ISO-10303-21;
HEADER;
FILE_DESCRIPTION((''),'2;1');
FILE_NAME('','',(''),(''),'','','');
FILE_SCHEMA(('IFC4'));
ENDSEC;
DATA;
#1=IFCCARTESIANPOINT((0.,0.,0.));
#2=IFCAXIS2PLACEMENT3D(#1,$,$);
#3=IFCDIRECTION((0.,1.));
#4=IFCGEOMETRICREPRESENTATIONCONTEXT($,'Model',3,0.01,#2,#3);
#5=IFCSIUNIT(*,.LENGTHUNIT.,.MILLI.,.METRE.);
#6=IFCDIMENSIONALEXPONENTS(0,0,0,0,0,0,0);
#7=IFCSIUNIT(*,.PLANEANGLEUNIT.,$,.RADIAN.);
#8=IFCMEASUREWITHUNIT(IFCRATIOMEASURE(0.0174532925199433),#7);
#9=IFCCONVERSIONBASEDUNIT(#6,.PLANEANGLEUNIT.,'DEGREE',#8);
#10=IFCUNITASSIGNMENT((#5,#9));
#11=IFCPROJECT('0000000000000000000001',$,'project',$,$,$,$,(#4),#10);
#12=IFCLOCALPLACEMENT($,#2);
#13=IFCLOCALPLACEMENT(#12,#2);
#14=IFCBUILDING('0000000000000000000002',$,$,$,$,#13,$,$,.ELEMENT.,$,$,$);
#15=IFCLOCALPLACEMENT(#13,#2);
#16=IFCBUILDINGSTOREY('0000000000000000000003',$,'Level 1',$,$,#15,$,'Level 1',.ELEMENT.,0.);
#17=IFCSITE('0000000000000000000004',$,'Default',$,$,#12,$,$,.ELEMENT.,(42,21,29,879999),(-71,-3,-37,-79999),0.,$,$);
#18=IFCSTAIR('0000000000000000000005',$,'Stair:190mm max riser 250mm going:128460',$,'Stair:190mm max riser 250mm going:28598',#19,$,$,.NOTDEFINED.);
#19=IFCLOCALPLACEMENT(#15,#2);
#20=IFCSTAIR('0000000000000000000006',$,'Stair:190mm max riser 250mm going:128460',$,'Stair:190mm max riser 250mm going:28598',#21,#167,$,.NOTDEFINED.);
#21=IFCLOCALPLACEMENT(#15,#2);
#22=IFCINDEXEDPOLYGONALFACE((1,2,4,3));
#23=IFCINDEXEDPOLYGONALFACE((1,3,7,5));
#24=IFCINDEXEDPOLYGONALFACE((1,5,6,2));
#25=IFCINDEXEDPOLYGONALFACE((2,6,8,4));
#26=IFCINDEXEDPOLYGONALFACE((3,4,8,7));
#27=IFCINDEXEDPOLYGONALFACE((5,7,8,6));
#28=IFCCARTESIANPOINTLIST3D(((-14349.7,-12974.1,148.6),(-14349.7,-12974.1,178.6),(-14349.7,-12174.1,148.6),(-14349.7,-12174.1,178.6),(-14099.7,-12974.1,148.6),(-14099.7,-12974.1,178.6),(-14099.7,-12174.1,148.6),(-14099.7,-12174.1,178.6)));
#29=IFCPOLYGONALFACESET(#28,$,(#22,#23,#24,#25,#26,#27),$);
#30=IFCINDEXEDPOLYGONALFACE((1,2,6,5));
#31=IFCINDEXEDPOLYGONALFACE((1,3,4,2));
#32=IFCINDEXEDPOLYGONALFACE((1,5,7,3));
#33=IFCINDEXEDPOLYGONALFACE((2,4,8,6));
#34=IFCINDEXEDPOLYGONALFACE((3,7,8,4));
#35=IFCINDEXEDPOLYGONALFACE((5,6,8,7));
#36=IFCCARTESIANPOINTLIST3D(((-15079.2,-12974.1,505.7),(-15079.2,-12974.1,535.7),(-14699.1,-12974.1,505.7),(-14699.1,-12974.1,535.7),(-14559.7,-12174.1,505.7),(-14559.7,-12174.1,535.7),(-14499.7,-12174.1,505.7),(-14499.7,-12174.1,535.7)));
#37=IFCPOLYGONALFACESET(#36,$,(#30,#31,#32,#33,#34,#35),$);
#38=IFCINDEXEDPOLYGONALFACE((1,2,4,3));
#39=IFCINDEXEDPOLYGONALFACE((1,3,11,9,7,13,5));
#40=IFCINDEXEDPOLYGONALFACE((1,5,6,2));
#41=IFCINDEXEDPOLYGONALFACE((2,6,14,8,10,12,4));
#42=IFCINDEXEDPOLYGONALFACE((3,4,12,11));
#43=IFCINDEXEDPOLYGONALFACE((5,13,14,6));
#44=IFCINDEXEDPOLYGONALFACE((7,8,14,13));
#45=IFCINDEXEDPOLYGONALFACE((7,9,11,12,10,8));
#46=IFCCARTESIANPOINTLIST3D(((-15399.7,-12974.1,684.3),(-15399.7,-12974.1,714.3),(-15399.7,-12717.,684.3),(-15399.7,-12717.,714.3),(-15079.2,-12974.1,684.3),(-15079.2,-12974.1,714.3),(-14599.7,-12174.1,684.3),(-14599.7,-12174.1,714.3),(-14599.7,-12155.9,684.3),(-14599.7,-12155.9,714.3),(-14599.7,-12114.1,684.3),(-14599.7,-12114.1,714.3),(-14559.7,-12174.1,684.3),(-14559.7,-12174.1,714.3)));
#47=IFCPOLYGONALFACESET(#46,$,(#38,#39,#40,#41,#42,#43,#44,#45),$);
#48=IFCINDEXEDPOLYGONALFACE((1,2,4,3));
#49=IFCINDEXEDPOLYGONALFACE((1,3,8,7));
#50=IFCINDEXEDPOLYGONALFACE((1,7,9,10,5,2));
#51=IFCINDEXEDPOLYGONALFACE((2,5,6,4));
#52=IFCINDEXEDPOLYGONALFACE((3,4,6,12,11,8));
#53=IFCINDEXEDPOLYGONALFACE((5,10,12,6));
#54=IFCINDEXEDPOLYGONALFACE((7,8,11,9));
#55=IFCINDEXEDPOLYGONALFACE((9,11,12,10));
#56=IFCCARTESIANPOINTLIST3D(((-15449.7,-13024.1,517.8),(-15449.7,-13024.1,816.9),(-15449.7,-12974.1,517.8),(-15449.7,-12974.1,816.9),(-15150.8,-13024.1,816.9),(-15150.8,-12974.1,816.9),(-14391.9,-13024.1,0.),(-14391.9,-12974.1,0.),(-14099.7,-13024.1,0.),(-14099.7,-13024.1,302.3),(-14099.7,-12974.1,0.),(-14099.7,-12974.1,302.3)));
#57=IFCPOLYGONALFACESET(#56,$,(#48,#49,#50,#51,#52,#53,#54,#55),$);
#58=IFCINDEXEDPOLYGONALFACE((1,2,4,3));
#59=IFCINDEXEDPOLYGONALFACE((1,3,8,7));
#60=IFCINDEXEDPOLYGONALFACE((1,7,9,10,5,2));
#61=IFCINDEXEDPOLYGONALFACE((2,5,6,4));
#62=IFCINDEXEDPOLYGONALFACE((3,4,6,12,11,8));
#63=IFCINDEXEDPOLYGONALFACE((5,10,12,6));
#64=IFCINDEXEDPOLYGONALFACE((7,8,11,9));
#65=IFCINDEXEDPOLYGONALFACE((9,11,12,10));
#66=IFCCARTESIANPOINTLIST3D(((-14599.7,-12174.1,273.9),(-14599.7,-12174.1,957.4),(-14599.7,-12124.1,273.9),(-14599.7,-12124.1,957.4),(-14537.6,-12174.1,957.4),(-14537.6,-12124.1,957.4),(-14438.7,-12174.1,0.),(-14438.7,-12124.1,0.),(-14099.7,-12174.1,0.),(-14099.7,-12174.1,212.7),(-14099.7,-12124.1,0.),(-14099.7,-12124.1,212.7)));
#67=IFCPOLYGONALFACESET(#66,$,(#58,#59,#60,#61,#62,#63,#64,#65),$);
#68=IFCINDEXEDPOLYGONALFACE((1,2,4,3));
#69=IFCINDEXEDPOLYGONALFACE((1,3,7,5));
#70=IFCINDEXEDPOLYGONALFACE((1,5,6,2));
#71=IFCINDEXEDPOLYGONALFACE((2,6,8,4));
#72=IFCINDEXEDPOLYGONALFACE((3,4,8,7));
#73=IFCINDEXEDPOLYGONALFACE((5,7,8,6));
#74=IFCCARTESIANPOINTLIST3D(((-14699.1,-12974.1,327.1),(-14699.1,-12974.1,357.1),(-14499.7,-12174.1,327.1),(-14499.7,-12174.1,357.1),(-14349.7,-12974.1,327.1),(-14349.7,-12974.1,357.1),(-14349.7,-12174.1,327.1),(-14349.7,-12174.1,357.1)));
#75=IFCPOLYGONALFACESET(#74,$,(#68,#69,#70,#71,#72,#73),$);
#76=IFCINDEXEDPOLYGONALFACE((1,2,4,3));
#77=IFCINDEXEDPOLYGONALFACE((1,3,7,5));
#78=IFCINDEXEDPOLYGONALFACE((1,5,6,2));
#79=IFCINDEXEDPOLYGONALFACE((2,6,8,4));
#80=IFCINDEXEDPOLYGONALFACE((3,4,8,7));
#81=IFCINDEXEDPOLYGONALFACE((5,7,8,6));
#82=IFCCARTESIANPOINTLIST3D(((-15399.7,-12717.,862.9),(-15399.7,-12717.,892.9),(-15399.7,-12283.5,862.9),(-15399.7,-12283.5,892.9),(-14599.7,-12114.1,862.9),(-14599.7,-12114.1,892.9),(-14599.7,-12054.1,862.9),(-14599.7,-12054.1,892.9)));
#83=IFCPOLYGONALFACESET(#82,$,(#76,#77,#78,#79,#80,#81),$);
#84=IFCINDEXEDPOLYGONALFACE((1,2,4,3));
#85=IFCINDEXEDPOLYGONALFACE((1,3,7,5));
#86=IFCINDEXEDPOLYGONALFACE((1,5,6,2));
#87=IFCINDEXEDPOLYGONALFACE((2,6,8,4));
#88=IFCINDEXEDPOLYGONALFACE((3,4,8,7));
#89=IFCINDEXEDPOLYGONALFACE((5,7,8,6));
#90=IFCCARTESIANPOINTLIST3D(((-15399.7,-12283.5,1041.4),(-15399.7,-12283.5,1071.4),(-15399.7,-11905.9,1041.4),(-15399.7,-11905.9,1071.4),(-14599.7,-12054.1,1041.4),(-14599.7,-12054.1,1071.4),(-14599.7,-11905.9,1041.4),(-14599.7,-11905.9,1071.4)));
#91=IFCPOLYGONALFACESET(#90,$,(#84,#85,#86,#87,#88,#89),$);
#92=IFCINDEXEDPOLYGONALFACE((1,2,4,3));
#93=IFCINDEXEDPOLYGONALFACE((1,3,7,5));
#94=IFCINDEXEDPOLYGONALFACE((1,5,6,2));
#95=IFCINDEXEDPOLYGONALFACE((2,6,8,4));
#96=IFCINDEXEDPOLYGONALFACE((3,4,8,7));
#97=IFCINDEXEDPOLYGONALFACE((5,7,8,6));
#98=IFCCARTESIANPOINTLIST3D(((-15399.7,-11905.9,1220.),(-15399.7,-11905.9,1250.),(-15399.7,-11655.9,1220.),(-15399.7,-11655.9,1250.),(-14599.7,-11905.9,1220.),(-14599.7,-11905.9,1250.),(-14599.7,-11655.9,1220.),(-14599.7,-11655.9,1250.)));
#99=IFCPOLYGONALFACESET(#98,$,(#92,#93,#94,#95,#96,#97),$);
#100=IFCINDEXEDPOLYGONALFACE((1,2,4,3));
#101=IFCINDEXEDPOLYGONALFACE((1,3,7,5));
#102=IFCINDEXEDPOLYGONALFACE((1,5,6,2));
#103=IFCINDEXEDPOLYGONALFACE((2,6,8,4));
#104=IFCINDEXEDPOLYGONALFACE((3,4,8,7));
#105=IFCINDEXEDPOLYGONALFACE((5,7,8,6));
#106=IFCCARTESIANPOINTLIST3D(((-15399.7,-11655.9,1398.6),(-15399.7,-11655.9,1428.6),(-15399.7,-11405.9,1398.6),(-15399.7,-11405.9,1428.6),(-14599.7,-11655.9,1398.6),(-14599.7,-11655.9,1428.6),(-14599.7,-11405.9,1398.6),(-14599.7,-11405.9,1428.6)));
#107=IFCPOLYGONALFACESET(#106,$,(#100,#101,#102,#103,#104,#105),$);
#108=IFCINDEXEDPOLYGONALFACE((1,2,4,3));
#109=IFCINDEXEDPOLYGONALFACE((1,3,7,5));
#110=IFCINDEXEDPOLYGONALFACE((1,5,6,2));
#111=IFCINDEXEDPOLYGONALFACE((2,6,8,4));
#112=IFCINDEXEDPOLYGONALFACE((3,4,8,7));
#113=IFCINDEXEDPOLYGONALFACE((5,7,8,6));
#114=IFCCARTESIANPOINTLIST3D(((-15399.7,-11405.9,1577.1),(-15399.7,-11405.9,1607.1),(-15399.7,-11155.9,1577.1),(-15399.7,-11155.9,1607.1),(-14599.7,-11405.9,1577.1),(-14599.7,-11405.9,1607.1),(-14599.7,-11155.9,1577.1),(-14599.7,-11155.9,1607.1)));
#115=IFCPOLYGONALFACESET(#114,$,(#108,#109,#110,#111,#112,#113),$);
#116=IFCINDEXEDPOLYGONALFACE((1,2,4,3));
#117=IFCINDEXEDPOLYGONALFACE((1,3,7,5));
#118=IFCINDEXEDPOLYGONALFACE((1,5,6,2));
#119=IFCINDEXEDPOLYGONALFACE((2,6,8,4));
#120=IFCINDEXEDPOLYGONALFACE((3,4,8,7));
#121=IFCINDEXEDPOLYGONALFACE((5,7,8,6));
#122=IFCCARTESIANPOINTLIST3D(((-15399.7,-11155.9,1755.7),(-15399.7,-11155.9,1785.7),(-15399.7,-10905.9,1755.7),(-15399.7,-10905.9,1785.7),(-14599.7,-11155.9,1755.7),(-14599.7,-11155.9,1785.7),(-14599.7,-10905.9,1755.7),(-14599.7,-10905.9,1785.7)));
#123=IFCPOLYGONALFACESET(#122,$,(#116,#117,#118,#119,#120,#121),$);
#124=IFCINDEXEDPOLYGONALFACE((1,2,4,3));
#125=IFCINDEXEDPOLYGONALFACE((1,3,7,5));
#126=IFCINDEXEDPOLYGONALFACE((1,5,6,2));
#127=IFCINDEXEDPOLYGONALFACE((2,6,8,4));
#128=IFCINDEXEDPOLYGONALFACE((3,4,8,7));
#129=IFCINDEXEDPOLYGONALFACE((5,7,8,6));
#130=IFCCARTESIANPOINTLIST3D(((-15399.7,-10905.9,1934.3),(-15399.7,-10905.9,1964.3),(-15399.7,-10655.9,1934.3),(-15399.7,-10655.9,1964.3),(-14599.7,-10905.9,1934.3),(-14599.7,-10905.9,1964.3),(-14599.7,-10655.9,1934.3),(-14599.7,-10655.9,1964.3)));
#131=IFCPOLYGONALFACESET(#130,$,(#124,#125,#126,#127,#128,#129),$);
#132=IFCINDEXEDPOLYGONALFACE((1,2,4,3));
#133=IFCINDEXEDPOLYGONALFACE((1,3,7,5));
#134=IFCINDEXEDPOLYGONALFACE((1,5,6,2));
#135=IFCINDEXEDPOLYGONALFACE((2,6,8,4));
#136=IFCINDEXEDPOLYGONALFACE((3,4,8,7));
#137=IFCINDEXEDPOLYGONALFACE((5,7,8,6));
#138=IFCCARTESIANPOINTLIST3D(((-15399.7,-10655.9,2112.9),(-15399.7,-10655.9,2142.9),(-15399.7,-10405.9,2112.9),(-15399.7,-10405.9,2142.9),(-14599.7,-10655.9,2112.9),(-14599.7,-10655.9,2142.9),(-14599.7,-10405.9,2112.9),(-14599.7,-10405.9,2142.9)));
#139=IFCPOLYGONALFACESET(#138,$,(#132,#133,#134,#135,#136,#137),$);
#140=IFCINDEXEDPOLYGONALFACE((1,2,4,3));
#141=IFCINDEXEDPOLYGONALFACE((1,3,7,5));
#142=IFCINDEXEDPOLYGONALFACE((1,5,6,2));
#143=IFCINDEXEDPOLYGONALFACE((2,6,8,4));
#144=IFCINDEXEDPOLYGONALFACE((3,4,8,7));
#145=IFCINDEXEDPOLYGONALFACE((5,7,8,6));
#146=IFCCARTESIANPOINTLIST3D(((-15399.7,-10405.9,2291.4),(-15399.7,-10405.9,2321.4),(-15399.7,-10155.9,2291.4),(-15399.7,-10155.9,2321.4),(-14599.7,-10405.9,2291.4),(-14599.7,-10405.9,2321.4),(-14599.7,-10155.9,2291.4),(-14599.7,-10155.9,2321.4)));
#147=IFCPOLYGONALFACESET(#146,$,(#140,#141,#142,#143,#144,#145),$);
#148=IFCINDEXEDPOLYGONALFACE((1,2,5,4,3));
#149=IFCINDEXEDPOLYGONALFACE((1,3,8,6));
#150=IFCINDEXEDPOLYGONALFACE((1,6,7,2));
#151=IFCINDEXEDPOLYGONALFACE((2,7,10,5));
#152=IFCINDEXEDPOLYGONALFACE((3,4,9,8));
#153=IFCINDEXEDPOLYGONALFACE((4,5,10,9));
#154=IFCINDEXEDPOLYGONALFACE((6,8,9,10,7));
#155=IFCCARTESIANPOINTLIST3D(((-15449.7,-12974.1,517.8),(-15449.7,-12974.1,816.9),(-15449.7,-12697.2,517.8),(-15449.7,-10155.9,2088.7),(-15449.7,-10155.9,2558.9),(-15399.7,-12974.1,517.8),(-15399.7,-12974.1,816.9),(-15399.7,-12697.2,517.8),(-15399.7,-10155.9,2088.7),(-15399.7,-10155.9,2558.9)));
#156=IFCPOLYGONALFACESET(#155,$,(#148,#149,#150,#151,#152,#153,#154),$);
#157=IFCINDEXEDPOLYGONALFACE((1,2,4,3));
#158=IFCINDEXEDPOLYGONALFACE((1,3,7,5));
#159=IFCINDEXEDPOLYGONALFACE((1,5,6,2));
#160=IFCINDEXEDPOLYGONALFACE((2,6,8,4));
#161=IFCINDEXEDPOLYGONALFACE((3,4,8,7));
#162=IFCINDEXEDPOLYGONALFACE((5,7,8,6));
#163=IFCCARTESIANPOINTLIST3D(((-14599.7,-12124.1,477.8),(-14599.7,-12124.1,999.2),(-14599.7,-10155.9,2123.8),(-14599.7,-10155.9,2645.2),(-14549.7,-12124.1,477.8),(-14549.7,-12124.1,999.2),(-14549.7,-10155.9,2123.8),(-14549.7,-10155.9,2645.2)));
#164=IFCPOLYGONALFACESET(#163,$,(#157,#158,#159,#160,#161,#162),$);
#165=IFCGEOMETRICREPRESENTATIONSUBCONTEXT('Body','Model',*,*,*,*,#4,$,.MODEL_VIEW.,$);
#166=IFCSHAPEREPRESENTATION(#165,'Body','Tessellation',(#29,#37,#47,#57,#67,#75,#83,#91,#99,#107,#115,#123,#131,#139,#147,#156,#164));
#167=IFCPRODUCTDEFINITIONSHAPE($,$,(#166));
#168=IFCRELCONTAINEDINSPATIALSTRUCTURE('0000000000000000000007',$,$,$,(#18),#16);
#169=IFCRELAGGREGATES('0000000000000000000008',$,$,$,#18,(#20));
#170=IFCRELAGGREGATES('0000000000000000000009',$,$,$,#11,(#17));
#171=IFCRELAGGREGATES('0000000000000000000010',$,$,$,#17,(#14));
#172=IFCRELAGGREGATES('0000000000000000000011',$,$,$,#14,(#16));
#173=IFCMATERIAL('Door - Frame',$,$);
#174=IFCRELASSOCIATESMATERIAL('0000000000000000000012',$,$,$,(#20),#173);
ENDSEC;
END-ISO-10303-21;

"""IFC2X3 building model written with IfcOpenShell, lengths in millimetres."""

from ifc_helpers import new_model, entity, si_unit, converted_unit, direction, frame, frame_2d, origin, place, context, subcontext, project, spatial, polyline, rectangle, outline, extrude, material, element, aggregate, save


model = new_model("IFC2X3")

# Units and contexts
model_context = context("Model", 3, precision=0.01, world=origin(), true_north=direction((0.0, 1.0)))
body_context = subcontext(model_context, "Body", "Model", "MODEL_VIEW")
ifc_project = project(units=[si_unit("LENGTHUNIT", "METRE", prefix="MILLI"), converted_unit("PLANEANGLEUNIT", "DEGREE", entity("IfcRatioMeasure", 0.0174532925199433), si_unit("PLANEANGLEUNIT", "RADIAN"), dimensions=[0, 0, 0, 0, 0, 0, 0])], contexts=[model_context])

# Site, building, storey
site_placement = place(None, origin())
site = spatial("IfcSite", under=ifc_project, at=site_placement, Name="Default", CompositionType="ELEMENT", RefLatitude=(42, 21, 29, 879999), RefLongitude=(-71, -3, -37, -79999), RefElevation=0.0)
building_placement = place(site_placement, origin())
building = spatial("IfcBuilding", under=site, at=building_placement, CompositionType="ELEMENT")
storey_placement = place(building_placement, origin())
storey = spatial("IfcBuildingStorey", under=building, at=storey_placement, Name="Level 1", LongName="Level 1", CompositionType="ELEMENT", Elevation=0.0)

# Shared definitions
ifc_material_1 = material(Name="Door - Frame")

# Stairs
stair_1_placement = place(storey_placement, origin())
stair_1 = element("IfcStair", 1, at=stair_1_placement, inside=storey, Name="Stair:190mm max riser 250mm going:128460", ObjectType="Stair:190mm max riser 250mm going:28598", ShapeType="NOTDEFINED")
stair_2_placement = place(stair_1_placement, origin())
stair_2 = element("IfcStair", 2, at=stair_2_placement, material=ifc_material_1, Name="Stair:190mm max riser 250mm going:128460", ObjectType="Stair:190mm max riser 250mm going:28598", ShapeType="NOTDEFINED", context=body_context, shape_type="SweptSolid", body=[
    extrude(rectangle(XDim=250.0, YDim=800.0, at=frame_2d((0.0, 0.0), x_axis=(1.0, 0.0))), frame((-14224.7, -12574.1, 148.6)), (0.0, 0.0, 1.0), 30.0),
    extrude(outline(polyline([(-369.8, -400.0), (10.3, -400.0), (209.7, 400.0), (149.7, 400.0), (-369.8, -400.0)])), frame((-14709.4, -12574.1, 505.7)), (0.0, 0.0, 1.0), 30.0),
    extrude(outline(polyline([(247.9, -508.6), (505.1, -508.6), (505.1, -188.2), (-294.9, 331.4), (-294.9, 291.4), (-313.2, 291.4), (-354.9, 291.4), (247.9, -508.6)])), frame((-14891.0, -12469.1, 684.3), z_axis=(0.0, 0.0, 1.0), x_axis=(0.0, -1.0, 0.0)), (0.0, 0.0, 1.0), 30.0),
    extrude(outline(polyline([(-673.9, -409.0), (-381.7, -409.0), (676.1, 108.9), (676.1, 407.9), (377.2, 407.9), (-673.9, -106.7), (-673.9, -409.0)])), frame((-14773.6, -13024.1, 409.0), z_axis=(0.0, 1.0, 0.0), x_axis=(-1.0, 0.0, 0.0)), (0.0, 0.0, 1.0), 50.0),
    extrude(outline(polyline([(-296.1, -400.2), (42.8, -400.2), (203.9, -126.4), (203.9, 557.2), (141.8, 557.2), (-296.1, -187.5), (-296.1, -400.2)])), frame((-14395.8, -12174.1, 400.2), z_axis=(0.0, 1.0, 0.0), x_axis=(-1.0, 0.0, 0.0)), (0.0, 0.0, 1.0), 50.0),
    extrude(outline(polyline([(-224.6, -400.0), (124.9, -400.0), (124.9, 400.0), (-25.1, 400.0), (-224.6, -400.0)])), frame((-14474.5, -12574.1, 327.1)), (0.0, 0.0, 1.0), 30.0),
    extrude(outline(polyline([(-8.7, -400.0), (424.8, -400.0), (-178.1, 400.0), (-238.1, 400.0), (-8.7, -400.0)])), frame((-14999.7, -12292.2, 862.9), z_axis=(0.0, 0.0, 1.0), x_axis=(0.0, -1.0, 0.0)), (0.0, 0.0, 1.0), 30.0),
    extrude(outline(polyline([(-131.5, -400.0), (246.2, -400.0), (16.8, 400.0), (-131.5, 400.0), (-131.5, -400.0)])), frame((-14999.7, -12037.4, 1041.4), z_axis=(0.0, 0.0, 1.0), x_axis=(0.0, -1.0, 0.0)), (0.0, 0.0, 1.0), 30.0),
    extrude(rectangle(XDim=250.0, YDim=800.0, at=frame_2d((0.0, 0.0), x_axis=(1.0, 0.0))), frame((-14999.7, -11780.9, 1220.0), z_axis=(0.0, 0.0, 1.0), x_axis=(0.0, -1.0, 0.0)), (0.0, 0.0, 1.0), 30.0),
    extrude(rectangle(XDim=250.0, YDim=800.0, at=frame_2d((0.0, 0.0), x_axis=(1.0, 0.0))), frame((-14999.7, -11530.9, 1398.6), z_axis=(0.0, 0.0, 1.0), x_axis=(0.0, -1.0, 0.0)), (0.0, 0.0, 1.0), 30.0),
    extrude(rectangle(XDim=250.0, YDim=800.0, at=frame_2d((0.0, 0.0), x_axis=(1.0, 0.0))), frame((-14999.7, -11280.9, 1577.1), z_axis=(0.0, 0.0, 1.0), x_axis=(0.0, -1.0, 0.0)), (0.0, 0.0, 1.0), 30.0),
    extrude(rectangle(XDim=250.0, YDim=800.0, at=frame_2d((0.0, 0.0), x_axis=(1.0, 0.0))), frame((-14999.7, -11030.9, 1755.7), z_axis=(0.0, 0.0, 1.0), x_axis=(0.0, -1.0, 0.0)), (0.0, 0.0, 1.0), 30.0),
    extrude(rectangle(XDim=250.0, YDim=800.0, at=frame_2d((0.0, 0.0), x_axis=(1.0, 0.0))), frame((-14999.7, -10780.9, 1934.3), z_axis=(0.0, 0.0, 1.0), x_axis=(0.0, -1.0, 0.0)), (0.0, 0.0, 1.0), 30.0),
    extrude(rectangle(XDim=250.0, YDim=800.0, at=frame_2d((0.0, 0.0), x_axis=(1.0, 0.0))), frame((-14999.7, -10530.9, 2112.9), z_axis=(0.0, 0.0, 1.0), x_axis=(0.0, -1.0, 0.0)), (0.0, 0.0, 1.0), 30.0),
    extrude(rectangle(XDim=250.0, YDim=800.0, at=frame_2d((0.0, 0.0), x_axis=(1.0, 0.0))), frame((-14999.7, -10280.9, 2291.4), z_axis=(0.0, 0.0, 1.0), x_axis=(0.0, -1.0, 0.0)), (0.0, 0.0, 1.0), 30.0),
    extrude(outline(polyline([(-1182.7, -782.2), (-905.7, -782.2), (1635.5, 788.7), (1635.5, 1258.9), (-1182.7, -483.2), (-1182.7, -782.2)])), frame((-15449.7, -11791.5, 1300.0), z_axis=(1.0, 0.0, 0.0), x_axis=(0.0, 1.0, 0.0)), (0.0, 0.0, 1.0), 50.0),
    extrude(outline(polyline([(-1450.1, -200.0), (1115.6, -200.0), (1450.1, 200.0), (-1115.6, 200.0), (-1450.1, -200.0)])), frame((-14599.7, -11140.0, 1561.5), z_axis=(1.0, 0.0, 0.0), x_axis=(0.0, 0.767103, 0.641524)), (0.0, 0.0, 1.0), 50.0),
])

aggregate(stair_1, [stair_2])

save(model, "model.ifc")
